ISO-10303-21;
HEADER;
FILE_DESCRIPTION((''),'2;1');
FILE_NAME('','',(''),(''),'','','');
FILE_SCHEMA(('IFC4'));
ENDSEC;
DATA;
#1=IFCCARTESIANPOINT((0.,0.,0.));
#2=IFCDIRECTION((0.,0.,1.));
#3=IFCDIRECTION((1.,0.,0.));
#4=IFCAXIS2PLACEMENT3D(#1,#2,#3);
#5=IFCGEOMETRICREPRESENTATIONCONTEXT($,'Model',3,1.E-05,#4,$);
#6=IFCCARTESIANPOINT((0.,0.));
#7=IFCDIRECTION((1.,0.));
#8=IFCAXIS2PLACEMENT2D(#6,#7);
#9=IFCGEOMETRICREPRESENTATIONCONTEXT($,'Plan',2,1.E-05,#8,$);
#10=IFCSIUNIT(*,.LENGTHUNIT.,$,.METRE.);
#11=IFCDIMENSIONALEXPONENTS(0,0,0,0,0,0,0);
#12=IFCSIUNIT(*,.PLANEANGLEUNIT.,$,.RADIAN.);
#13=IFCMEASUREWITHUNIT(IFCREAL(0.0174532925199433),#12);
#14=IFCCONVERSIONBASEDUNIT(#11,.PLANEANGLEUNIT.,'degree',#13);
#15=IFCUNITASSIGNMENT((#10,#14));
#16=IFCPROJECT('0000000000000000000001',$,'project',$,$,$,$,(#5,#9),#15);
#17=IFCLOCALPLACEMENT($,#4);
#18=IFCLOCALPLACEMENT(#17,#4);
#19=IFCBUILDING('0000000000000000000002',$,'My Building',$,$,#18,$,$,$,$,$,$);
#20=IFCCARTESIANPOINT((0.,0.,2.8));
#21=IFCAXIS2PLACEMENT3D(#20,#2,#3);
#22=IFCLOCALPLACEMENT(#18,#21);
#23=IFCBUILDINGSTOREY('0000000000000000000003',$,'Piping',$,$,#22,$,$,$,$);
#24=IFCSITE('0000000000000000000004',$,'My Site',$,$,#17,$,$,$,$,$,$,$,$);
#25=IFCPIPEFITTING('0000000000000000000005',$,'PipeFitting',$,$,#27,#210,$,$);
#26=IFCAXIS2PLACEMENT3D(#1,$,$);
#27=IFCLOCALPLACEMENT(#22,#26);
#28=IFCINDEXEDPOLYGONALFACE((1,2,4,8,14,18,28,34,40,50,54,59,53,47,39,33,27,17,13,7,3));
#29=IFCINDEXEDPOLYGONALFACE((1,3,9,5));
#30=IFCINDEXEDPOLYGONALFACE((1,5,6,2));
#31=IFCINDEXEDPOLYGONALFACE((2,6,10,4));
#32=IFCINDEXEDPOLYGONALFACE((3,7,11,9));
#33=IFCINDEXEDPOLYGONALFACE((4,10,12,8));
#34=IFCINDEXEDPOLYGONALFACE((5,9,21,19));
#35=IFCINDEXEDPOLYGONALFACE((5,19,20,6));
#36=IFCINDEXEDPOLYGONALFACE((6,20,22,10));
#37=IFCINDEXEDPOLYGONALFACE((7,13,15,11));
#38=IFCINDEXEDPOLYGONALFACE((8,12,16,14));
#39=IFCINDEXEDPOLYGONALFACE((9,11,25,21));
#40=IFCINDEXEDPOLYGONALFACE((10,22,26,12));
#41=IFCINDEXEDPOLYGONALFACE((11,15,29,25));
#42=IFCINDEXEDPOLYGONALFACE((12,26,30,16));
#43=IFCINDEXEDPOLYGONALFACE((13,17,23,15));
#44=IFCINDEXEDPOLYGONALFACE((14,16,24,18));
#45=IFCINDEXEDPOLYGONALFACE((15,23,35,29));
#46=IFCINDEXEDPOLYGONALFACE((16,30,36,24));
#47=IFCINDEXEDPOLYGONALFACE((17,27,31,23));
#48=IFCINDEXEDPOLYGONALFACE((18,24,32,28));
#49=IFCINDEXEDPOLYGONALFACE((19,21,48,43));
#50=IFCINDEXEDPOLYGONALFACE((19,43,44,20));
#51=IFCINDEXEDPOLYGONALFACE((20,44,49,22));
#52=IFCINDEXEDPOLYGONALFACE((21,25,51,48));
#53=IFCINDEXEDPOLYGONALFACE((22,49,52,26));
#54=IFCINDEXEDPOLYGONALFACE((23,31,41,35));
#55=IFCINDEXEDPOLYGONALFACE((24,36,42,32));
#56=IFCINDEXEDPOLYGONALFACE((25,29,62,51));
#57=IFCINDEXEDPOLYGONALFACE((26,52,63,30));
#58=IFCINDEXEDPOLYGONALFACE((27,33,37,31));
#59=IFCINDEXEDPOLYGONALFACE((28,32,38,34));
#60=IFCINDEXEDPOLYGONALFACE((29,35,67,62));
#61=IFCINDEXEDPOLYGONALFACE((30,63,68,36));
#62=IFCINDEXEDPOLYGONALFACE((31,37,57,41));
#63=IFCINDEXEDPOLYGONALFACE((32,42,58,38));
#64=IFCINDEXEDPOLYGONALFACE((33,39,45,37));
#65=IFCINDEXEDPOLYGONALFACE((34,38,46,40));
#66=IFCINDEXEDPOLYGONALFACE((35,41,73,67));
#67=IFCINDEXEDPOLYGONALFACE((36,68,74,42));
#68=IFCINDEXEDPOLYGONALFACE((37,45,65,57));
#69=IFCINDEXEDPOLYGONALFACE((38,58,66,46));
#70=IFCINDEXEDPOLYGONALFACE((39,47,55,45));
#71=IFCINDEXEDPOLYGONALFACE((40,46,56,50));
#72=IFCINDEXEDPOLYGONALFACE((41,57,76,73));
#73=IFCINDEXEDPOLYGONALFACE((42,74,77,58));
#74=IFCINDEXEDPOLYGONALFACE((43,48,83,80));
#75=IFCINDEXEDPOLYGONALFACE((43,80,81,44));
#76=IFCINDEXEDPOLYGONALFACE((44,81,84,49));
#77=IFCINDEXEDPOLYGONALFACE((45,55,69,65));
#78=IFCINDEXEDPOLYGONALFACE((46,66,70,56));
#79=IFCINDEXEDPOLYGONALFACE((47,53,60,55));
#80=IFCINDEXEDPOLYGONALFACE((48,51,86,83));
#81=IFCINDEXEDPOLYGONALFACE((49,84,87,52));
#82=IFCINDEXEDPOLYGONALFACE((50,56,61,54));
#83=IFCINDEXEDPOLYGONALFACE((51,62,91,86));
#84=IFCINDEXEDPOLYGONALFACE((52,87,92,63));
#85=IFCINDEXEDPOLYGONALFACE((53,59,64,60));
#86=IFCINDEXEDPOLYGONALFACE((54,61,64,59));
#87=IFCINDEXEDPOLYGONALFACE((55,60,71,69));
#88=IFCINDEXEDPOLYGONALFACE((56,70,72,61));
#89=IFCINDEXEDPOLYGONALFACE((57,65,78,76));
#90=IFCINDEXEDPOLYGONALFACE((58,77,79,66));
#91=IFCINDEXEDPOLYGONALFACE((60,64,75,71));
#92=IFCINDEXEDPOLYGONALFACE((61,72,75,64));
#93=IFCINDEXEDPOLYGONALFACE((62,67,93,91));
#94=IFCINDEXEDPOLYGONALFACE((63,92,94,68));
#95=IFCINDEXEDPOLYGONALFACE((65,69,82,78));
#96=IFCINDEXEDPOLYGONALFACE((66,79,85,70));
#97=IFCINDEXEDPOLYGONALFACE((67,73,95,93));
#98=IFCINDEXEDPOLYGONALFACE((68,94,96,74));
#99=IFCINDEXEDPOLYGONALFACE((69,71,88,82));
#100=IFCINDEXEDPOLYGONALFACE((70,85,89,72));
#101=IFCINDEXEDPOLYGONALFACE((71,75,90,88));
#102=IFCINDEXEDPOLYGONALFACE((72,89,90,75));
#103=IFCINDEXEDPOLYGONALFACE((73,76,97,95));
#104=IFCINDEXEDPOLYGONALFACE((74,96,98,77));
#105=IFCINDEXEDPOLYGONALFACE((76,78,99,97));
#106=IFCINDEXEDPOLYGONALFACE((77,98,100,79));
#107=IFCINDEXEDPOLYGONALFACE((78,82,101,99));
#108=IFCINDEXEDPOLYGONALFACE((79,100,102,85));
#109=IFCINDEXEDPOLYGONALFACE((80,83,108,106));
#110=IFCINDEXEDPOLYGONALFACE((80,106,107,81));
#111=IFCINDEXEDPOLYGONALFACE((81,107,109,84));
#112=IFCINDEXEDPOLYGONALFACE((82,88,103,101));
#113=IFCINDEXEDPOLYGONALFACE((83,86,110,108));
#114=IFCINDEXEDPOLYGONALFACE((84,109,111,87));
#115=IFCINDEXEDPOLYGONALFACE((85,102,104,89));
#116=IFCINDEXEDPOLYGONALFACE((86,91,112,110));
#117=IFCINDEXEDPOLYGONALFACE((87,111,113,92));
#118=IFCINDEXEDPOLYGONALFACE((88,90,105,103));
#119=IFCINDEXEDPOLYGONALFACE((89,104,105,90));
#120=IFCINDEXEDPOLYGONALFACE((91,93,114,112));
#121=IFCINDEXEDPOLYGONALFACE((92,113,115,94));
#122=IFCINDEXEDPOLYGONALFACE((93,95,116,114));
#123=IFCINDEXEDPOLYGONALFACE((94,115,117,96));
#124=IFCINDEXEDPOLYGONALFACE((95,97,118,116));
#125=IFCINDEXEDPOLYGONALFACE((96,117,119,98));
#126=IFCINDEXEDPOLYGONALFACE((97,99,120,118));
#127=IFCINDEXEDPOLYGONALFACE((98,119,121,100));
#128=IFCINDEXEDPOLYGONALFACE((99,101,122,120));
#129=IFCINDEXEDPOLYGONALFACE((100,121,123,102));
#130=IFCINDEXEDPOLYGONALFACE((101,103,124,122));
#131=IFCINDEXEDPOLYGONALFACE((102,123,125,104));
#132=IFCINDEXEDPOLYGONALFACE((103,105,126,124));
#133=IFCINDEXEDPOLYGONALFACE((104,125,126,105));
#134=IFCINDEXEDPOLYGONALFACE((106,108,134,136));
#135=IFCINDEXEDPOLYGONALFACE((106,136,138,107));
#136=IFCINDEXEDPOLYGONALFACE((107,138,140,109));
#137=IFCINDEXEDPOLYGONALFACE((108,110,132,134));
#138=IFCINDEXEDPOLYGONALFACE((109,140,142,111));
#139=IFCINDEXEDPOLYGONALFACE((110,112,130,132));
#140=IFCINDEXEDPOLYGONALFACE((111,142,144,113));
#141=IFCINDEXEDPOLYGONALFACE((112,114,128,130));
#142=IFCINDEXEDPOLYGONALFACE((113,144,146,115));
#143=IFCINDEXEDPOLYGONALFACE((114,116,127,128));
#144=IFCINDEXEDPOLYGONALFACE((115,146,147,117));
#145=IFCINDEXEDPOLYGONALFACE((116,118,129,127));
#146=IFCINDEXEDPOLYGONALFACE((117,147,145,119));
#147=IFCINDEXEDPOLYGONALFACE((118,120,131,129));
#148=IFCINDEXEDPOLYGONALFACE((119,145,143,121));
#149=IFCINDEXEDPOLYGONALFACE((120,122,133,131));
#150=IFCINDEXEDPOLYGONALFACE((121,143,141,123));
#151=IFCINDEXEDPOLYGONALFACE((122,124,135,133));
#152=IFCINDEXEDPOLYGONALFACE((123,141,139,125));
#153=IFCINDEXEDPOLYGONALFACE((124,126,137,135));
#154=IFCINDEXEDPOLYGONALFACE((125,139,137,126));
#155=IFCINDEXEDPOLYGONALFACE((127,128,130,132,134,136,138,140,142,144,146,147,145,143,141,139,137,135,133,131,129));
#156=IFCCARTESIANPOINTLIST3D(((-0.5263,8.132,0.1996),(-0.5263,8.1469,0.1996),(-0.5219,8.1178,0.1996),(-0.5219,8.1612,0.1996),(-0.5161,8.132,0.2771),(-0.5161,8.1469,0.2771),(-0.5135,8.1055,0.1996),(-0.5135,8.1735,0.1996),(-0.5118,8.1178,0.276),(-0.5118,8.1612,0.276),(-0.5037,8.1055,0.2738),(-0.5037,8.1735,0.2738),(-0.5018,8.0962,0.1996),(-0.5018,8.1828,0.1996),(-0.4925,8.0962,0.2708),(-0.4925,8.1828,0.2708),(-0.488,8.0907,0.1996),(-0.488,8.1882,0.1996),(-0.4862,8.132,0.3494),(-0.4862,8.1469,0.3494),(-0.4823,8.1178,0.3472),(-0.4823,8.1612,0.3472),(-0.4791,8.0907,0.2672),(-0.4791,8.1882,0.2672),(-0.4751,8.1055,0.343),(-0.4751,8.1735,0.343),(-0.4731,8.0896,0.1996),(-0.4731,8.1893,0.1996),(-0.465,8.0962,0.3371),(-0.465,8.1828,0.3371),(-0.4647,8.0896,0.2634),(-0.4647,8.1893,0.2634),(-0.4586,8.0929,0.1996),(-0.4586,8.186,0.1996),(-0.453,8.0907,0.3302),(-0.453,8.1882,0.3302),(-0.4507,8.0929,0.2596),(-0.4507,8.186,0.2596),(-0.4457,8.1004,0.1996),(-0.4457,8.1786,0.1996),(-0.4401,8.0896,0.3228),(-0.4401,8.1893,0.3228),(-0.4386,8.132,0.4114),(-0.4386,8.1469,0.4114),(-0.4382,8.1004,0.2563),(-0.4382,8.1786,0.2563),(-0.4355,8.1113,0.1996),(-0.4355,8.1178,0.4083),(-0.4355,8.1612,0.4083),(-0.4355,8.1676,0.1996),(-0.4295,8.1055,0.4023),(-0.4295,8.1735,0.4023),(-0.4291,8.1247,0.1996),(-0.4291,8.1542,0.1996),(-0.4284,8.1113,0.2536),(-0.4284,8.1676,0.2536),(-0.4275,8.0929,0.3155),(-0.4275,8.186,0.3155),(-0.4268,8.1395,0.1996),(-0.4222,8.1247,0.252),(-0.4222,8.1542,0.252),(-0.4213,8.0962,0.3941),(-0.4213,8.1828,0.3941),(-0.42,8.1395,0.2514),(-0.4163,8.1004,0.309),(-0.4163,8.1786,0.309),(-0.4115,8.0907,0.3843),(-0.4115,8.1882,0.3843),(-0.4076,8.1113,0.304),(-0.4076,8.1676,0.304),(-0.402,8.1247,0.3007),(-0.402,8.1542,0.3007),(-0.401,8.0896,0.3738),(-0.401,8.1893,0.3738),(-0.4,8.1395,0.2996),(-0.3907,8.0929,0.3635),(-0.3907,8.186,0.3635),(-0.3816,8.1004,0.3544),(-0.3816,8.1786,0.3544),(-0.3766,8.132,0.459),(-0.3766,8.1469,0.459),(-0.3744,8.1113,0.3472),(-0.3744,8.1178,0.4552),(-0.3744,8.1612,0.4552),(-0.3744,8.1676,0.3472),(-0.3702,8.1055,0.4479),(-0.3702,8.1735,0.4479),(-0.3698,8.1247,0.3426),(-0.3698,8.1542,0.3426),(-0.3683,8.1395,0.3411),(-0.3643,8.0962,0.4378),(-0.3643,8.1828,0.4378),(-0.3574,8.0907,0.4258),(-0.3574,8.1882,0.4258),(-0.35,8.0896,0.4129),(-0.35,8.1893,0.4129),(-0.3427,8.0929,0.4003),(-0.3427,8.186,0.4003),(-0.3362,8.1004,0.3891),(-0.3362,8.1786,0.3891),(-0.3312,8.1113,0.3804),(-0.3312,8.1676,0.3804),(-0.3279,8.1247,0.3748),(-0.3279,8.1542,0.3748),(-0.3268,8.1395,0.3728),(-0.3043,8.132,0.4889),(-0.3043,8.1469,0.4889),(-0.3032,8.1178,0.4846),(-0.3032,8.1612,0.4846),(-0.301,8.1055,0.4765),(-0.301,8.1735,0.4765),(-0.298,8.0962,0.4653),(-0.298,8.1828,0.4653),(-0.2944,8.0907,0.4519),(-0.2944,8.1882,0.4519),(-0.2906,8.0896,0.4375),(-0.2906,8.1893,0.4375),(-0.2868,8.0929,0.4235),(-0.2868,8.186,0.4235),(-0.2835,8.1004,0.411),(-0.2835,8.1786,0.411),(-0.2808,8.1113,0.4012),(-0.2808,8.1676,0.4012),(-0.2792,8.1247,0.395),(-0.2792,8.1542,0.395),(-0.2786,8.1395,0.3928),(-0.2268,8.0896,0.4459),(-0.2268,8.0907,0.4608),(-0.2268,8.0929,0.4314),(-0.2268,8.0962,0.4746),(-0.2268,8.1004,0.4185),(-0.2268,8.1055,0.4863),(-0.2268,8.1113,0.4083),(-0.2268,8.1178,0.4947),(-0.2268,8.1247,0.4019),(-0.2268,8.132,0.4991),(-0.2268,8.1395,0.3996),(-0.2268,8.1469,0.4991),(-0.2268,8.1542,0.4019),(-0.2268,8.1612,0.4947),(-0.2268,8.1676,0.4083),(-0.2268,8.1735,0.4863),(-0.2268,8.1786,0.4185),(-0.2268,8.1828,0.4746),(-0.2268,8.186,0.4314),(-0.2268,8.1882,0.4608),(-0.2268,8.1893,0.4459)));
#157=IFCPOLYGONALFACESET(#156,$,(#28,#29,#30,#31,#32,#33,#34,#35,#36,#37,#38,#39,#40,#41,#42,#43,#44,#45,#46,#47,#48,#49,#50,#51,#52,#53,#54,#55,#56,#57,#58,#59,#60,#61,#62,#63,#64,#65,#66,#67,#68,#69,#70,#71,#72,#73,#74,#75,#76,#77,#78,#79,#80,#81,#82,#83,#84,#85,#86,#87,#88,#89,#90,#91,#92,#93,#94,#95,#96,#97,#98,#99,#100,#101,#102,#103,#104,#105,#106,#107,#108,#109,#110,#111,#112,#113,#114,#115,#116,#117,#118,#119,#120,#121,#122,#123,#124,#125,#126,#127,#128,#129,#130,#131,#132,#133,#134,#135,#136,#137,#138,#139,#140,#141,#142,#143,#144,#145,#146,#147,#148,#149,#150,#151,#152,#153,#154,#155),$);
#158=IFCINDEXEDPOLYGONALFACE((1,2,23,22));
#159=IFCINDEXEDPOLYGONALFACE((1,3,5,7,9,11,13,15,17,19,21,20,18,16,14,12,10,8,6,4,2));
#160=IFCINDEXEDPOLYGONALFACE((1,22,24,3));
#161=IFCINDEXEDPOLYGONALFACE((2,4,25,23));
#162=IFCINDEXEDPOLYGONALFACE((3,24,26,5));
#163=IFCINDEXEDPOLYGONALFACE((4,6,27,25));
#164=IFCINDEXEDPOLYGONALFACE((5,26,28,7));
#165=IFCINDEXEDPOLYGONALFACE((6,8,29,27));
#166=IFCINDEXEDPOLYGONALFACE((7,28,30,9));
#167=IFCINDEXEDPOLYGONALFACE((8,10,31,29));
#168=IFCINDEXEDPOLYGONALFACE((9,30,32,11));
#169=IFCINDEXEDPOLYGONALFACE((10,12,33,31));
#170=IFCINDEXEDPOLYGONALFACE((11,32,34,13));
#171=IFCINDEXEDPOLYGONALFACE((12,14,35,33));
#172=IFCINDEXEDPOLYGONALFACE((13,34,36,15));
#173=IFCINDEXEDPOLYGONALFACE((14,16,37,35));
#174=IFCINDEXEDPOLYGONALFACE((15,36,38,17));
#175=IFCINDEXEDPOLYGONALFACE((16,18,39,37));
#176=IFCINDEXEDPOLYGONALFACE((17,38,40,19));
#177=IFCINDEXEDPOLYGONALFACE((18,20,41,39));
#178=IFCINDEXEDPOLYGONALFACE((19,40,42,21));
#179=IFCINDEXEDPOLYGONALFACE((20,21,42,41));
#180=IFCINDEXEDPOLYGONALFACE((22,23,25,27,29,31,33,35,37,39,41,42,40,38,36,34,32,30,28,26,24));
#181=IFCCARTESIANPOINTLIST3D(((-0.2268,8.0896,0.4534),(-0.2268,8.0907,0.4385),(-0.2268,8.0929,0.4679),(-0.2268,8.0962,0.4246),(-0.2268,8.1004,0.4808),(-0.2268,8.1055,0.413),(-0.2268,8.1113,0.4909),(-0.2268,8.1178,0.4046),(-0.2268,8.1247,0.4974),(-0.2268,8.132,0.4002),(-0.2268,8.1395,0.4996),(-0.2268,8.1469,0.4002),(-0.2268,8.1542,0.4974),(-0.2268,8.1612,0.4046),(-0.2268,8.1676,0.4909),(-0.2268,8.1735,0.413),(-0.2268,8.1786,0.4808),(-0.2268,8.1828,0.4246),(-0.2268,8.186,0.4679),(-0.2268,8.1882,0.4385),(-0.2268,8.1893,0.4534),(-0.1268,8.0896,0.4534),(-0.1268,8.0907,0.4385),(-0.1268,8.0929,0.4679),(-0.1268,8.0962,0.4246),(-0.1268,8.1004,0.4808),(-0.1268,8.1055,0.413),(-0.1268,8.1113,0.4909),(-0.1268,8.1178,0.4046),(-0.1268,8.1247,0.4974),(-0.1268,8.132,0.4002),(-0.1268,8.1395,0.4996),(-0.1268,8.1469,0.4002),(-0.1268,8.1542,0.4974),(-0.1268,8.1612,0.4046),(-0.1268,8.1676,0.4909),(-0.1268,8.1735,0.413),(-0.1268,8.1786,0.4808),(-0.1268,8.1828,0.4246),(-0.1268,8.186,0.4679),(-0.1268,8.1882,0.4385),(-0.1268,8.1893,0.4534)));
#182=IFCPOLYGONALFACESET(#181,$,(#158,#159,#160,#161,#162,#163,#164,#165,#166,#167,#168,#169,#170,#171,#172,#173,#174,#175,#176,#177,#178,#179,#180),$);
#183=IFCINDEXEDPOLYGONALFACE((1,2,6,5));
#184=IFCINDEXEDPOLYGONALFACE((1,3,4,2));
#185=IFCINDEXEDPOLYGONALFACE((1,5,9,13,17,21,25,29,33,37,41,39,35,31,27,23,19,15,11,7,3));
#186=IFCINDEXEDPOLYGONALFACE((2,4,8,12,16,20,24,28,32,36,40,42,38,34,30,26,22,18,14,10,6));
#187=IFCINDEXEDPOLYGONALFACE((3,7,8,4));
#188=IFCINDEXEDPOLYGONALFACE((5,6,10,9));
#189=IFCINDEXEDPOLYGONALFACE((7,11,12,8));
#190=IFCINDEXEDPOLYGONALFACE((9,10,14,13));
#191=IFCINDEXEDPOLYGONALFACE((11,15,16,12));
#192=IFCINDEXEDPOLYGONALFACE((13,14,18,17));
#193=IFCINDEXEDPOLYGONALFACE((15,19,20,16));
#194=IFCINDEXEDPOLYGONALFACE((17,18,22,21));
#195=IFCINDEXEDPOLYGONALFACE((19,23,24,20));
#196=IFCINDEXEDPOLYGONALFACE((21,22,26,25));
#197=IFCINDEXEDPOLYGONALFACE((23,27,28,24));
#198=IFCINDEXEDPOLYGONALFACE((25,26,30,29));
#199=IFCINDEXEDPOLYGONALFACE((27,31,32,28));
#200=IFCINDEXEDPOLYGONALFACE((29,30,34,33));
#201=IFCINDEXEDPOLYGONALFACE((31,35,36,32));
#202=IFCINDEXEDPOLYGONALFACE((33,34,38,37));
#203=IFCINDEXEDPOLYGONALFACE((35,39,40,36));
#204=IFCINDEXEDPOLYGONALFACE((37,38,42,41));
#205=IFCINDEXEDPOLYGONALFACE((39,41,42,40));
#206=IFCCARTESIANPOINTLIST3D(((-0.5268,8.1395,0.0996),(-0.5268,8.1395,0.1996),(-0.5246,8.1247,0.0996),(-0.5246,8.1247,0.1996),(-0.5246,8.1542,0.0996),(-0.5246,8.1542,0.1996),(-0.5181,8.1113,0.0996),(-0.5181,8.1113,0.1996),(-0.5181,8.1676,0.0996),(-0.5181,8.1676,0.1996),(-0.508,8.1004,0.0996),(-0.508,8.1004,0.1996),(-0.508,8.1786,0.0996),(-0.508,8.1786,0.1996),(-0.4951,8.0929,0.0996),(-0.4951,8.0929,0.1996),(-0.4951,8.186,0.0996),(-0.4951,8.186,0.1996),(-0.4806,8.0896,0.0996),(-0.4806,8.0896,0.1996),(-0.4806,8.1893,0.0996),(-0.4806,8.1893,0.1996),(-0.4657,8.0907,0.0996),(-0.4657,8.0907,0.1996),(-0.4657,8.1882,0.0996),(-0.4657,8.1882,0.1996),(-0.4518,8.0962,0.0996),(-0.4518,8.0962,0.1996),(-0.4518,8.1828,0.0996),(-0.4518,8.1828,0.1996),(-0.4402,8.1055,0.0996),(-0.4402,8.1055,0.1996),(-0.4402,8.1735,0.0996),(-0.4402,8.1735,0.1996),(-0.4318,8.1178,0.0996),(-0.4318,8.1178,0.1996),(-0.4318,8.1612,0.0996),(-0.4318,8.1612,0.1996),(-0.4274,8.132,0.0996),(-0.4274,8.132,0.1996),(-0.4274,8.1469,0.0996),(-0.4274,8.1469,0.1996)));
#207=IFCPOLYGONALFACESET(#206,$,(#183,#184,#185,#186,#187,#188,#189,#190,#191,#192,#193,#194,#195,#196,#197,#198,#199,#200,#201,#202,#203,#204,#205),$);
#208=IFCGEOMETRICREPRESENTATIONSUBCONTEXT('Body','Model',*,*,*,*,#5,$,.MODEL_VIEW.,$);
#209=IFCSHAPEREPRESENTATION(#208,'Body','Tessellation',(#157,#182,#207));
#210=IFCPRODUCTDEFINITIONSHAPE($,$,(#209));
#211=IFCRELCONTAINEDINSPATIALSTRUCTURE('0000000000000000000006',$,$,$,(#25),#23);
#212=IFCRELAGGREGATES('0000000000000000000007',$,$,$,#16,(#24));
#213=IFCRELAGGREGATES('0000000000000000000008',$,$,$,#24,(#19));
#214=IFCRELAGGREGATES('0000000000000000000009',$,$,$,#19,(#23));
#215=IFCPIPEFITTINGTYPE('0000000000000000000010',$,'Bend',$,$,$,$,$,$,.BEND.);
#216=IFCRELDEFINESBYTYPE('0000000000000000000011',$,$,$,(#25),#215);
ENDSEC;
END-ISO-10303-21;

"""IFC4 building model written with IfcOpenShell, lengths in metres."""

from ifc_helpers import new_model, entity, si_unit, converted_unit, frame, origin_with_axes, origin_2d_with_axis, place, context, subcontext, project, spatial, circle, extrude, source, transform, mapped, type_object, type_shapes, element, save


model = new_model("IFC4")

# Units and contexts
model_context = context("Model", 3, precision=1e-05, world=origin_with_axes())
plan_context = context("Plan", 2, precision=1e-05, world=origin_2d_with_axis())
body_context = subcontext(model_context, "Body", "Model", "MODEL_VIEW")
ifc_project = project(units=[si_unit("LENGTHUNIT", "METRE"), converted_unit("PLANEANGLEUNIT", "degree", entity("IfcReal", 0.0174532925199433), si_unit("PLANEANGLEUNIT", "RADIAN"), dimensions=[0, 0, 0, 0, 0, 0, 0])], contexts=[model_context, plan_context])

# Site, building, storey
site_placement = place(None, origin_with_axes())
site = spatial("IfcSite", under=ifc_project, at=site_placement, Name="My Site")
building_placement = place(site_placement, origin_with_axes())
building = spatial("IfcBuilding", under=site, at=building_placement, Name="My Building")
storey_placement = place(building_placement, frame((0.0, 0.0, 2.8), z_axis=(0.0, 0.0, 1.0), x_axis=(1.0, 0.0, 0.0)))
storey = spatial("IfcBuildingStorey", under=building, at=storey_placement, Name="Piping")

# Pipe fitting
pipe_fitting_type_1 = type_object("IfcPipeFittingType", Name="Bend", PredefinedType="BEND")
shared_shape_1 = source(origin_with_axes(), body_context, "Body", "SolidModel", [
    entity("IfcSweptDiskSolid", entity("IfcIndexedPolyCurve", entity("IfcCartesianPointList3D", [[0.0, 0.0, -0.1], [-0.0732, 0.0, -0.2768], [-0.25, 0.0, -0.35]]), [entity("IfcArcIndex", [1, 2, 3])]), 0.05),
    extrude(circle(Radius=0.05), origin_with_axes(), (0.0, 0.0, -1.0), 0.1),
    extrude(circle(Radius=0.05), frame((-0.25, 0.0, -0.35), z_axis=(-1.0, 0.0, 0.0), x_axis=(0.0, 0.0, -1.0)), (0.0, 0.0, 1.0), 0.1),
])
type_shapes(pipe_fitting_type_1, [shared_shape_1])
for number, where, z_axis, x_axis, name in (
    (1, (-0.1268, 8.1395, 0.4496), (1.0, 0.0, 0.0), (0.0, 0.0, 1.0), "PipeFitting"),
):
    element("IfcPipeFitting", number, at=place(storey_placement, frame(where, z_axis=z_axis, x_axis=x_axis)), inside=storey, type_object=pipe_fitting_type_1, Name=name, context=body_context, shape_type="MappedRepresentation", body=[
        mapped(shared_shape_1, transform((0.0, 0.0, 0.0), x_axis=(1.0, 0.0, 0.0), y_axis=(0.0, 1.0, 0.0), z_axis=(0.0, 0.0, 1.0), scale=1.0)),
    ])

save(model, "model.ifc")
